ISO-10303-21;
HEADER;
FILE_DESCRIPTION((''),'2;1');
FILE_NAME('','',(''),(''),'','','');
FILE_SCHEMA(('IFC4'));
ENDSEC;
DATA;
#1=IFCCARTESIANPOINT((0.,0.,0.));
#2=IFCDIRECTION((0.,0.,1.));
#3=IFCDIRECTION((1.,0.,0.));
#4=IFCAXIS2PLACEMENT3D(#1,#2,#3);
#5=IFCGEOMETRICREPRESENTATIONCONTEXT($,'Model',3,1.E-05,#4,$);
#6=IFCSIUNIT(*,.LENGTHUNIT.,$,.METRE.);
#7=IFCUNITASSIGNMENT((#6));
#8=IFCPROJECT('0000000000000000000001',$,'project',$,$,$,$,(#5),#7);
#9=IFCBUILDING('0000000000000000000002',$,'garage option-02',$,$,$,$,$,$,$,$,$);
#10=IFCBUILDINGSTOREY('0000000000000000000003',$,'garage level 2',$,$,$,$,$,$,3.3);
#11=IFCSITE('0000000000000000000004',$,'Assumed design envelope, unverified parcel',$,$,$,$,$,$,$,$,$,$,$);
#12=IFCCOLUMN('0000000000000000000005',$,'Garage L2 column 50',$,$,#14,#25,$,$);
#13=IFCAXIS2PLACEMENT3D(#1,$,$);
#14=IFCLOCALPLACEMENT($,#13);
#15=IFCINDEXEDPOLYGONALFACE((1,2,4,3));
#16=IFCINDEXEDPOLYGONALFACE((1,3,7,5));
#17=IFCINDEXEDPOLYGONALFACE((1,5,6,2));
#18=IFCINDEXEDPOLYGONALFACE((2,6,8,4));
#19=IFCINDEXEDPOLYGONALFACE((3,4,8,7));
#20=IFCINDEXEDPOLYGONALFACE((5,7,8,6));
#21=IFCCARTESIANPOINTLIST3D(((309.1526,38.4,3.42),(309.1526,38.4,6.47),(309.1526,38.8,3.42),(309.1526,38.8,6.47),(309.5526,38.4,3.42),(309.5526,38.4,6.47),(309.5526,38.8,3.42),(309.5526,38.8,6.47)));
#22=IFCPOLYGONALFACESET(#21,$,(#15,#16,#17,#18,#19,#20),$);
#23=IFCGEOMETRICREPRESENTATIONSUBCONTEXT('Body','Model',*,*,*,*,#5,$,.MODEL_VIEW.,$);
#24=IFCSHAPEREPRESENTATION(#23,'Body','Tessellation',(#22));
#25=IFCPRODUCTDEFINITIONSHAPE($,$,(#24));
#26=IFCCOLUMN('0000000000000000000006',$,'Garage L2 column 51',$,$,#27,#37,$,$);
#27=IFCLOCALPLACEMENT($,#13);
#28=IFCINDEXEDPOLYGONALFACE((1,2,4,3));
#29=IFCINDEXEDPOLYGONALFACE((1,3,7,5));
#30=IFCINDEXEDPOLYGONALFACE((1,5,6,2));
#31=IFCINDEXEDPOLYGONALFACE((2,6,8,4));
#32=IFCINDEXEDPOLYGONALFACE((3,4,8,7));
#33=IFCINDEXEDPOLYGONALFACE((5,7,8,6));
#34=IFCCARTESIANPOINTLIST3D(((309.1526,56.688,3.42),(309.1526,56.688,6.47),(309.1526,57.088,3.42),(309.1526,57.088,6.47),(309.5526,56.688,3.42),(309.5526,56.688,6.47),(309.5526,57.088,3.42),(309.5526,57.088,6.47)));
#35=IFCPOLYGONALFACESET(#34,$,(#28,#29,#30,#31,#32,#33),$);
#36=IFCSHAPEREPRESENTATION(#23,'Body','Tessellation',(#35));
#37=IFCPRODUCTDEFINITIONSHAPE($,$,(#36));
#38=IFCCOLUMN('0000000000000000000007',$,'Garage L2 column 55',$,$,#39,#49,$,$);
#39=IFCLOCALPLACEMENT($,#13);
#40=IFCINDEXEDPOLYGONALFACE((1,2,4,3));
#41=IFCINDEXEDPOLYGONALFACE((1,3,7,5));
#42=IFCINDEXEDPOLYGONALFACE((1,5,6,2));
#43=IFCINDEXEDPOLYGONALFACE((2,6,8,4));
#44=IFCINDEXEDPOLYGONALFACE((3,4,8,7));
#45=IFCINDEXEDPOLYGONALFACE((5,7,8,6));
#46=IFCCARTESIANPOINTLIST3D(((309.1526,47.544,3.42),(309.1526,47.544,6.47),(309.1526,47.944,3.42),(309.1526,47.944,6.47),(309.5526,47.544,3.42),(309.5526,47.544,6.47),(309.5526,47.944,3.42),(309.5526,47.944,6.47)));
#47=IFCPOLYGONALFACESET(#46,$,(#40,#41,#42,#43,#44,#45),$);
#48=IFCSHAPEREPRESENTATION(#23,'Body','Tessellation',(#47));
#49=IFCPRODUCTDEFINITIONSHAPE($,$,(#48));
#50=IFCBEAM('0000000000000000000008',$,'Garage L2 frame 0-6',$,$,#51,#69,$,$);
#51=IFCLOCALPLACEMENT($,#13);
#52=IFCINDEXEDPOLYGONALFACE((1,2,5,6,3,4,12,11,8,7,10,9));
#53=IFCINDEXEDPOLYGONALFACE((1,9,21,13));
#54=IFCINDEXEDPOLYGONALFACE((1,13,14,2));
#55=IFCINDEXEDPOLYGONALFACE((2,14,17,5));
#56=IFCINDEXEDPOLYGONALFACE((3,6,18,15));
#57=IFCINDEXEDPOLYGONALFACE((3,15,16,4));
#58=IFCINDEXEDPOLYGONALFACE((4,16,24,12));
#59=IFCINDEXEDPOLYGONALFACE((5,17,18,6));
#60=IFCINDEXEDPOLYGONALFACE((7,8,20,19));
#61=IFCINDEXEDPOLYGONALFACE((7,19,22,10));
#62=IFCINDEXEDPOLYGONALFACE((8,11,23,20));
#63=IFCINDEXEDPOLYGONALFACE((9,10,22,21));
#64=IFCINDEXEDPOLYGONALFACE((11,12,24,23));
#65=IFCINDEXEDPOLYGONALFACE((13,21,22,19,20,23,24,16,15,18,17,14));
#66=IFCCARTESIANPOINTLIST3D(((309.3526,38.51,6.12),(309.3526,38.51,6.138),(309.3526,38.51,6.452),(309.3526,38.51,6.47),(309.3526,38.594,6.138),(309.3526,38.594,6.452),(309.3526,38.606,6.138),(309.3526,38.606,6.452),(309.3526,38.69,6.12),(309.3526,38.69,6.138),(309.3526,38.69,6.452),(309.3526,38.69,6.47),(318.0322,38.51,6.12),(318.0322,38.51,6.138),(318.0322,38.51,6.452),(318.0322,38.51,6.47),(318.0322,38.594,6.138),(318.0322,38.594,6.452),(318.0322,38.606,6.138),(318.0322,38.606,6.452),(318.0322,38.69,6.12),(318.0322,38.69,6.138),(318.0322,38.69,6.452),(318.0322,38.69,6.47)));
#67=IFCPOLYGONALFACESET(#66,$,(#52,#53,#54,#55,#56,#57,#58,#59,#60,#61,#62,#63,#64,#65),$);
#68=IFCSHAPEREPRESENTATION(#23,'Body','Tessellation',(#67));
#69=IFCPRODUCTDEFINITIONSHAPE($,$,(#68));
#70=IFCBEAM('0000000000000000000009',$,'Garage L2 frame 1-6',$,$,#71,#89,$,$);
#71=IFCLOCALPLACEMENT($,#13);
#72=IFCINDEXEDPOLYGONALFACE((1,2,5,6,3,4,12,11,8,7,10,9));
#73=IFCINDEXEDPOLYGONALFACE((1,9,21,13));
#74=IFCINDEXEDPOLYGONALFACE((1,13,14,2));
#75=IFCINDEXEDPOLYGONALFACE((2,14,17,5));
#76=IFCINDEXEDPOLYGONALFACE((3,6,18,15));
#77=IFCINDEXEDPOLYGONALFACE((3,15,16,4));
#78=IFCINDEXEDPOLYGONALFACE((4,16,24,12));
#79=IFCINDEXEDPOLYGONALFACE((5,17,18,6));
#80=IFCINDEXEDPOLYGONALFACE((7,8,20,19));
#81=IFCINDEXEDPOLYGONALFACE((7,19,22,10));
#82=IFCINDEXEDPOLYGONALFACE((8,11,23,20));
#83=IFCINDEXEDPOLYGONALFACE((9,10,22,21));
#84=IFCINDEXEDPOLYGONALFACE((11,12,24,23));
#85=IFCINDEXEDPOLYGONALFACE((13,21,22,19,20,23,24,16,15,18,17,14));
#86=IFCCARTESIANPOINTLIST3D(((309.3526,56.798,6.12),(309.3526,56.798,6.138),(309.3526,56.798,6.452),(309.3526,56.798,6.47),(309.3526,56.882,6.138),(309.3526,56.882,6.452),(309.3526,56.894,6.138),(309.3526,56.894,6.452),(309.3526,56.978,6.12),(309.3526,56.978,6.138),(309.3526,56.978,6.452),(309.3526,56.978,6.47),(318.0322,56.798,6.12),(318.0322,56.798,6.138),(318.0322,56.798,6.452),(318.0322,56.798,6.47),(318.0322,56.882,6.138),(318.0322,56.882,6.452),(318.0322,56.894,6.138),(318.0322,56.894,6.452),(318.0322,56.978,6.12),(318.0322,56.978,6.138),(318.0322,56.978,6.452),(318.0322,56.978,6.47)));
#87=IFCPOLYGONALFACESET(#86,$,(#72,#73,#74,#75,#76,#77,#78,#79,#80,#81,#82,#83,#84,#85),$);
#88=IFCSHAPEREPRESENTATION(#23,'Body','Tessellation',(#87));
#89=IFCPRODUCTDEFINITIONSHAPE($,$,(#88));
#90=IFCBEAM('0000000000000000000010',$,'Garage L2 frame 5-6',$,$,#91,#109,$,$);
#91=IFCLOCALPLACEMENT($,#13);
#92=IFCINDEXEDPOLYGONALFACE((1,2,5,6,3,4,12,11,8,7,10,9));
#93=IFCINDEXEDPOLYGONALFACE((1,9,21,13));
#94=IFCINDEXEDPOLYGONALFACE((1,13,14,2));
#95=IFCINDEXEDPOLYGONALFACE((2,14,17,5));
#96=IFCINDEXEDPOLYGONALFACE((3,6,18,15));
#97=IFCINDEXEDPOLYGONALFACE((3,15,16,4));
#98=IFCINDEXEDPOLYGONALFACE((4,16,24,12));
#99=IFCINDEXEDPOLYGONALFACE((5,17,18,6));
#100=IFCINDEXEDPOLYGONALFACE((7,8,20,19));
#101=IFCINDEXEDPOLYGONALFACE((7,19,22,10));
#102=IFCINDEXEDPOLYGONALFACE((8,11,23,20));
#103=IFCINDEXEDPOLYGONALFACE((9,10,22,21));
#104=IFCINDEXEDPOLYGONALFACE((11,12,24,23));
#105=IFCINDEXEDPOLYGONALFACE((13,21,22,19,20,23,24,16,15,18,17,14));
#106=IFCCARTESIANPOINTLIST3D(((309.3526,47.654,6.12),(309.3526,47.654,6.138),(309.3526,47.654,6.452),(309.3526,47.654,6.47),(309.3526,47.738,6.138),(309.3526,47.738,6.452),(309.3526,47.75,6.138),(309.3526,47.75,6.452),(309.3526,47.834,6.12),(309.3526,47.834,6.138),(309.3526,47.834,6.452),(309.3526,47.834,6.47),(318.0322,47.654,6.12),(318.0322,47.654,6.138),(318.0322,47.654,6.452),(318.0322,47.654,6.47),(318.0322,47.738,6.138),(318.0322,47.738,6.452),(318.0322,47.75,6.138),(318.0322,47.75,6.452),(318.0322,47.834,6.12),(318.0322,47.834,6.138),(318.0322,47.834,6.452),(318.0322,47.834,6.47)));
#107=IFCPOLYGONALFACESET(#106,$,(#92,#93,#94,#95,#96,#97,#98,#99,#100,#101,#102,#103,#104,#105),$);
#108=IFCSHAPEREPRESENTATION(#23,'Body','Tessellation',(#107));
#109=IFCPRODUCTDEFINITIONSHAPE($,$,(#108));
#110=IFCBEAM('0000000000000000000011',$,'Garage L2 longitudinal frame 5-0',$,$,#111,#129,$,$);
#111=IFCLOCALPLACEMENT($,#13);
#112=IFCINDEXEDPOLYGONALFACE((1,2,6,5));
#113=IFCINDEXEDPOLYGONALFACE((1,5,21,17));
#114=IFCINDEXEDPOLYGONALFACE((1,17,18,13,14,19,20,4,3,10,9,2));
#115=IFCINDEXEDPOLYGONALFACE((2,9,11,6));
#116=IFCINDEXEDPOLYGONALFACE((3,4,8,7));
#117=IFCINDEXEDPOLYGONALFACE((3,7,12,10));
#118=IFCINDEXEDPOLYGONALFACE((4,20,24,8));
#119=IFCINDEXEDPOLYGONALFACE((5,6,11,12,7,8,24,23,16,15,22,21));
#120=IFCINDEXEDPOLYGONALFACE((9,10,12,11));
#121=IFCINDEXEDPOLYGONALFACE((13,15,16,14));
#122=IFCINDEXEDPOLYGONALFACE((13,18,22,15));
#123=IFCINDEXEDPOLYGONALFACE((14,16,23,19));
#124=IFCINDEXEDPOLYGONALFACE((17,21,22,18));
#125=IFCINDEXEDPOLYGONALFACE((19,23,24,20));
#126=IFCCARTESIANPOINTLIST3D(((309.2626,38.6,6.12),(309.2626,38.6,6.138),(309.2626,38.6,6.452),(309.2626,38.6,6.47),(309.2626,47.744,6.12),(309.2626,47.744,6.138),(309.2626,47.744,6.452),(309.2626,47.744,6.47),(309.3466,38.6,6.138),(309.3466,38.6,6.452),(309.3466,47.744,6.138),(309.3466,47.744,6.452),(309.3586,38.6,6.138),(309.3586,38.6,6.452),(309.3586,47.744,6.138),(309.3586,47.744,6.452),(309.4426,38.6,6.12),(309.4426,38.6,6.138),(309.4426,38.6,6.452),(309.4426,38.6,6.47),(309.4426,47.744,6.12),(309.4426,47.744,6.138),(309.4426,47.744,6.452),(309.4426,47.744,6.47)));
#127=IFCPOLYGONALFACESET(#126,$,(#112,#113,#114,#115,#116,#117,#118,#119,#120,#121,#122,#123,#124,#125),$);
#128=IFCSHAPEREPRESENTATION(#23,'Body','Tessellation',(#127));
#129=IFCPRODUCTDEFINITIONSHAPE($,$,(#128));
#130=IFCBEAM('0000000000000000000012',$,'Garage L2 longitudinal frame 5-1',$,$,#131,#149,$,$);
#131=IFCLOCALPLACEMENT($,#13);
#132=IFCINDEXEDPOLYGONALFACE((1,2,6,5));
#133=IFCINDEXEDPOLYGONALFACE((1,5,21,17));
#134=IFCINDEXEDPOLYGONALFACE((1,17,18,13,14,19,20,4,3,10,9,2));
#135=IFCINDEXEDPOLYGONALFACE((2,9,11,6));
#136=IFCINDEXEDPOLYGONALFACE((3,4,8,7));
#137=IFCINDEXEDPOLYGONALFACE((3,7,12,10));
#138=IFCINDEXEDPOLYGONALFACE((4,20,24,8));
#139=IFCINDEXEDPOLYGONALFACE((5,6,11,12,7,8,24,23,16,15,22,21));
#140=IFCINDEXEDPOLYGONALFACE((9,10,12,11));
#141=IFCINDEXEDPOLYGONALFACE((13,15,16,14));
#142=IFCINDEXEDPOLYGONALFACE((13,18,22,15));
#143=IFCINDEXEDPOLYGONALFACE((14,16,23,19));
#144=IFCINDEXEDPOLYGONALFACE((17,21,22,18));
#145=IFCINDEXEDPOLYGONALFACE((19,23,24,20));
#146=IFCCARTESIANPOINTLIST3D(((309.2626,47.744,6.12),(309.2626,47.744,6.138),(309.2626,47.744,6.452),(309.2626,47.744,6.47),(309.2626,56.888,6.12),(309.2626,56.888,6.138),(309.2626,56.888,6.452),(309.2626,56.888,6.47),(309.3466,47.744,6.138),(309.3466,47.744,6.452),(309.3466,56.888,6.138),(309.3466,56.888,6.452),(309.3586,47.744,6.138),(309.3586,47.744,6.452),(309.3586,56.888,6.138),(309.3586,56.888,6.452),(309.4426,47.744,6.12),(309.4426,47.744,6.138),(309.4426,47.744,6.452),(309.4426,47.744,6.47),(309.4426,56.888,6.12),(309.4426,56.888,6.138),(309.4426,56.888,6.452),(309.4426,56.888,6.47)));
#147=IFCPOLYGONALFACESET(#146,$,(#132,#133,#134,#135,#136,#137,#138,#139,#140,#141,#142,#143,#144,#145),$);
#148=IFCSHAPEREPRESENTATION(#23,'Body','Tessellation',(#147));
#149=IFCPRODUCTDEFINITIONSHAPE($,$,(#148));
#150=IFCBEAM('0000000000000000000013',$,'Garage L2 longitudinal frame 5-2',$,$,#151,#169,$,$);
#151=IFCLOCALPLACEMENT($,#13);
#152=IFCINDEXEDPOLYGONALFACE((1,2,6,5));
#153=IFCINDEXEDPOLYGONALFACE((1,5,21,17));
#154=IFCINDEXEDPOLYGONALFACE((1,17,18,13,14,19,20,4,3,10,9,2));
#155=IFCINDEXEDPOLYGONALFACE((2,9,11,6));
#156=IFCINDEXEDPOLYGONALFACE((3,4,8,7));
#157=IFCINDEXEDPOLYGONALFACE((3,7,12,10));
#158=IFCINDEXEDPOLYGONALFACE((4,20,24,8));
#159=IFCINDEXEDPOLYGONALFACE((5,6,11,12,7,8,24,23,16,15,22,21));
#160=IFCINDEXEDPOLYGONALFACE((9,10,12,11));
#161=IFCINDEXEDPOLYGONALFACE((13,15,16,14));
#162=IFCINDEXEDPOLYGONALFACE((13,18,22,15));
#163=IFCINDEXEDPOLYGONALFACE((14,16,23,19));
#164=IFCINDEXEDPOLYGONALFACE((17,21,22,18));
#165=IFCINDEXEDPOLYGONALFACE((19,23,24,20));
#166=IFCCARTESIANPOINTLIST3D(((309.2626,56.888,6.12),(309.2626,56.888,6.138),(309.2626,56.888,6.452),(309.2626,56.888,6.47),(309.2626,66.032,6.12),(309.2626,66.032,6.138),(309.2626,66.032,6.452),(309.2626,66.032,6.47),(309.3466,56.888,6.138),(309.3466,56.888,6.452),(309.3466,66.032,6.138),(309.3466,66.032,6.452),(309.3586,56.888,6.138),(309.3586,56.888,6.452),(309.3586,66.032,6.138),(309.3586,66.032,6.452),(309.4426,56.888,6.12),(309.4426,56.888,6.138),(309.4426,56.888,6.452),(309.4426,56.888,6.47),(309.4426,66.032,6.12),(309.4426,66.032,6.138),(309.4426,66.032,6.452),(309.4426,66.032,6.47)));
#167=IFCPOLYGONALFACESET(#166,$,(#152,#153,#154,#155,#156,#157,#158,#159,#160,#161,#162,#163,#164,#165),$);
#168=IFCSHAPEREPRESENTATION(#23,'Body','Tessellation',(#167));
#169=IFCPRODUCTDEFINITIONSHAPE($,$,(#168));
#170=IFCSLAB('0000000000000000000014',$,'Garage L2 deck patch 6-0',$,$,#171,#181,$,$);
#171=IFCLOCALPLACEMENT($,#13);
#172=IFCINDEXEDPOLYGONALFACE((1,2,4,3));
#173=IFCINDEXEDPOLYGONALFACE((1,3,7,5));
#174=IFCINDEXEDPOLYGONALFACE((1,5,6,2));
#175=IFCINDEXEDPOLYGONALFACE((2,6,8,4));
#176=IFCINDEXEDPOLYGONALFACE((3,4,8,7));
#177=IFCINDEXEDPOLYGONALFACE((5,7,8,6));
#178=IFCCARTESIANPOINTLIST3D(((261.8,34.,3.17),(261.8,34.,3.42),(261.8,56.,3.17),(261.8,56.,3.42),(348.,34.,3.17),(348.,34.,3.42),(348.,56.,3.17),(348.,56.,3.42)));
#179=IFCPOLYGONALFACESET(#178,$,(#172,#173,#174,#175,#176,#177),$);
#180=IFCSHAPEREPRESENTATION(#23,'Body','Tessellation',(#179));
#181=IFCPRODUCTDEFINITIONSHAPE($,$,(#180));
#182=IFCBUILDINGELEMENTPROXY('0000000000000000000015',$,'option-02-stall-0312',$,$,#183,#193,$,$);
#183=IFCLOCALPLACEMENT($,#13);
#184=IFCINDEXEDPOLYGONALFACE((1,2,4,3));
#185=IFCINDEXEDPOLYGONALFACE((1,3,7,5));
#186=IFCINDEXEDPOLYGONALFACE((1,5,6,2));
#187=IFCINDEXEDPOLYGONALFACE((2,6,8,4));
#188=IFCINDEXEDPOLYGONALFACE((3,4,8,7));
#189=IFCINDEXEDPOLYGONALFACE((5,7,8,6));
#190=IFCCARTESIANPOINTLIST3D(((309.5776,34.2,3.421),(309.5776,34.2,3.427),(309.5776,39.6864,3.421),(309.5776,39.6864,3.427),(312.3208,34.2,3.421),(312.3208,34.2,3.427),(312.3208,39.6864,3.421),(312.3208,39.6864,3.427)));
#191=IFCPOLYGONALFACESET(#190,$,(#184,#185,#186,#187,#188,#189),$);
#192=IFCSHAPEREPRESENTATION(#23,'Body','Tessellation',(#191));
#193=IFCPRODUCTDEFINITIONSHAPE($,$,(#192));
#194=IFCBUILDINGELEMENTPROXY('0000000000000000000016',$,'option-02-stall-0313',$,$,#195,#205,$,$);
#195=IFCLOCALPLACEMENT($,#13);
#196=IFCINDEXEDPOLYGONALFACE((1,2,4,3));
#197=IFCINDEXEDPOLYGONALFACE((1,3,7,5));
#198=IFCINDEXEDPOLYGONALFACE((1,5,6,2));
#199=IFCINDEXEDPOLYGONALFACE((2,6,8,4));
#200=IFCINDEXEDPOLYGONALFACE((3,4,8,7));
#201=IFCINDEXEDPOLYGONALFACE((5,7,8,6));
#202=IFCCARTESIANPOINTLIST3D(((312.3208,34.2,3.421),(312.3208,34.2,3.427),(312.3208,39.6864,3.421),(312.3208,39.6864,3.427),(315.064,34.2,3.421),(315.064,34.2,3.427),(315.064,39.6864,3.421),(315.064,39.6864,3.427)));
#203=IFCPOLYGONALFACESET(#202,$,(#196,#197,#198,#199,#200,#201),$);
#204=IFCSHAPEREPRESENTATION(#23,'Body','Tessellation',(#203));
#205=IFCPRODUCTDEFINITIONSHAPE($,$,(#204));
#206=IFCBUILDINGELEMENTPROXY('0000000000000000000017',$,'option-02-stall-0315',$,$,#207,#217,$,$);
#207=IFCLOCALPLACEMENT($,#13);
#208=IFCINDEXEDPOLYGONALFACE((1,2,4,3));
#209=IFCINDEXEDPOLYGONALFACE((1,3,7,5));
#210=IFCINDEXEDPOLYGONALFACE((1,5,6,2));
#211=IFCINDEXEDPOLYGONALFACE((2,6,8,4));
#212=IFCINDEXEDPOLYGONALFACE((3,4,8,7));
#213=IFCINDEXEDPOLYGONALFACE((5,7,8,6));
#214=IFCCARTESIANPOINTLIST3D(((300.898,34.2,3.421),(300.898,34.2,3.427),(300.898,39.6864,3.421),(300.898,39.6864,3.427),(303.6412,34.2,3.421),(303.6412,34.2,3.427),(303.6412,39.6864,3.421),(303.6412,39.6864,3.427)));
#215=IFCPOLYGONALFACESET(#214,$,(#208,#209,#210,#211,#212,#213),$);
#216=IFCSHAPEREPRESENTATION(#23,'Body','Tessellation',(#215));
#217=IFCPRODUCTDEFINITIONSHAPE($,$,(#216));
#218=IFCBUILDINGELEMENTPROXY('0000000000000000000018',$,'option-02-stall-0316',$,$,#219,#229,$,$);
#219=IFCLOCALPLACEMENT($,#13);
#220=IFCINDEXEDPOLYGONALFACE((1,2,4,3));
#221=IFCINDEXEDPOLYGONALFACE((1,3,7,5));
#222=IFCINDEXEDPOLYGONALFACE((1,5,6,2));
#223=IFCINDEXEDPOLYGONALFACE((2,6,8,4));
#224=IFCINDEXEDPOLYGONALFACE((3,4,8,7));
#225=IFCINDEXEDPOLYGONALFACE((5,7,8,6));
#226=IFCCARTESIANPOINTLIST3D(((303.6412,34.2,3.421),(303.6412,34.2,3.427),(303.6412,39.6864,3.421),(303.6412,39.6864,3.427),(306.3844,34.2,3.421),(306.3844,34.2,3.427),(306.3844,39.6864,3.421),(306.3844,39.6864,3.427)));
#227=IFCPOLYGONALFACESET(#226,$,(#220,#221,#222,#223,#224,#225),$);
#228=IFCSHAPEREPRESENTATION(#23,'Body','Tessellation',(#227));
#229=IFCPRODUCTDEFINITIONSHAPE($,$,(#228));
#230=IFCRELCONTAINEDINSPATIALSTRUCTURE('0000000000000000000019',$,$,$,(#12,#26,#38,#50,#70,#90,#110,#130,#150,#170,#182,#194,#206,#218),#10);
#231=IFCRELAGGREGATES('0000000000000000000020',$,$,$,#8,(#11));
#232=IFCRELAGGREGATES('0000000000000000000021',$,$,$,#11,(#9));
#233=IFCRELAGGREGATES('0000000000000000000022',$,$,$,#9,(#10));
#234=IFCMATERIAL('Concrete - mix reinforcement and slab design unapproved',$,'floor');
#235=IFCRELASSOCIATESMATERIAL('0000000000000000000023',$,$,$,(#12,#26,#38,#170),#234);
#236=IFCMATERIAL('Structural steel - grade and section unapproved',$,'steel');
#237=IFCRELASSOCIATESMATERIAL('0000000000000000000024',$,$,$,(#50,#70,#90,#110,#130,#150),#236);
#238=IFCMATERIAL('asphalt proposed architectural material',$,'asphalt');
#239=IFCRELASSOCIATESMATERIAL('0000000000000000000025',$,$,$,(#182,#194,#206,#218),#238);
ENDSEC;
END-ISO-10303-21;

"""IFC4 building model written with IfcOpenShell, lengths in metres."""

from ifc_helpers import new_model, si_unit, frame, origin_with_axes, place, context, subcontext, project, spatial, rectangle, i_section, extrude, material, element, save


model = new_model("IFC4")

# Units and contexts
model_context = context("Model", 3, precision=1e-05, world=origin_with_axes())
body_context = subcontext(model_context, "Body", "Model", "MODEL_VIEW")
ifc_project = project(units=[si_unit("LENGTHUNIT", "METRE")], contexts=[model_context])

# Site, building, storey
site = spatial("IfcSite", under=ifc_project, Name="Assumed design envelope, unverified parcel")
building = spatial("IfcBuilding", under=site, Name="garage option-02")
storey = spatial("IfcBuildingStorey", under=building, Name="garage level 2", Elevation=3.3)

# Columns
ifc_material_1 = material(Name="Concrete - mix reinforcement and slab design unapproved", Category="floor")
for number, where, z_axis, x_axis, name in (
    (1, (309.3526, 38.6, 3.42), (0.0, 0.0, 1.0), (1.0, 0.0, 0.0), "Garage L2 column 50"),
    (2, (309.3526, 56.888, 3.42), (0.0, 0.0, 1.0), (1.0, 0.0, 0.0), "Garage L2 column 51"),
    (3, (309.3526, 47.744, 3.42), (0.0, 0.0, 1.0), (1.0, 0.0, 0.0), "Garage L2 column 55"),
):
    element("IfcColumn", number, at=place(None, frame(where, z_axis=z_axis, x_axis=x_axis)), inside=storey, material=ifc_material_1, Name=name, context=body_context, shape_type="SweptSolid", body=[
        extrude(rectangle(XDim=0.4, YDim=0.4), origin_with_axes(), (0.0, 0.0, 1.0), 3.05),
    ])

# Beams
ifc_material_2 = material(Name="Structural steel - grade and section unapproved", Category="steel")
for number, where, z_axis, x_axis, name in (
    (4, (309.3526, 38.6, 6.295), (1.0, 0.0, 0.0), (0.0, 1.0, 0.0), "Garage L2 frame 0-6"),
    (5, (309.3526, 56.888, 6.295), (1.0, 0.0, 0.0), (0.0, 1.0, 0.0), "Garage L2 frame 1-6"),
    (6, (309.3526, 47.744, 6.295), (1.0, 0.0, 0.0), (0.0, 1.0, 0.0), "Garage L2 frame 5-6"),
):
    element("IfcBeam", number, at=place(None, frame(where, z_axis=z_axis, x_axis=x_axis)), inside=storey, material=ifc_material_2, Name=name, context=body_context, shape_type="SweptSolid", body=[
        extrude(i_section(OverallWidth=0.18, OverallDepth=0.35, WebThickness=0.012, FlangeThickness=0.018, FilletRadius=0.0), origin_with_axes(), (0.0, 0.0, 1.0), 8.6796),
    ])
for number, where, z_axis, x_axis, name in (
    (7, (309.3526, 38.6, 6.295), (0.0, 1.0, 0.0), (-1.0, 0.0, 0.0), "Garage L2 longitudinal frame 5-0"),
    (8, (309.3526, 47.744, 6.295), (0.0, 1.0, 0.0), (-1.0, 0.0, 0.0), "Garage L2 longitudinal frame 5-1"),
):
    element("IfcBeam", number, at=place(None, frame(where, z_axis=z_axis, x_axis=x_axis)), inside=storey, material=ifc_material_2, Name=name, context=body_context, shape_type="SweptSolid", body=[
        extrude(i_section(OverallWidth=0.18, OverallDepth=0.35, WebThickness=0.012, FlangeThickness=0.018, FilletRadius=0.0), origin_with_axes(), (0.0, 0.0, 1.0), 9.144),
    ])
beam_placement = place(None, frame((309.3526, 56.888, 6.295), z_axis=(0.0, 1.0, 0.0), x_axis=(-1.0, 0.0, 0.0)))
element("IfcBeam", 9, at=beam_placement, inside=storey, material=ifc_material_2, Name="Garage L2 longitudinal frame 5-2", context=body_context, shape_type="SweptSolid", body=[
    extrude(i_section(OverallWidth=0.18, OverallDepth=0.35, WebThickness=0.012, FlangeThickness=0.018, FilletRadius=0.0), origin_with_axes(), (0.0, 0.0, 1.0), 9.144),
])

# Slab
slab_placement = place(None, frame((304.9, 45.0, 3.17), z_axis=(0.0, 0.0, 1.0), x_axis=(1.0, 0.0, 0.0)))
element("IfcSlab", 10, at=slab_placement, inside=storey, material=ifc_material_1, Name="Garage L2 deck patch 6-0", context=body_context, shape_type="SweptSolid", body=[
    extrude(rectangle(XDim=86.2, YDim=22.0), origin_with_axes(), (0.0, 0.0, 1.0), 0.25),
])

# Building element proxies
ifc_material_3 = material(Name="asphalt proposed architectural material", Category="asphalt")
for number, where, z_axis, x_axis, name in (
    (11, (310.9492, 36.9432, 3.421), (0.0, 0.0, 1.0), (1.0, 0.0, 0.0), "option-02-stall-0312"),
    (12, (313.6924, 36.9432, 3.421), (0.0, 0.0, 1.0), (1.0, 0.0, 0.0), "option-02-stall-0313"),
    (13, (302.2696, 36.9432, 3.421), (0.0, 0.0, 1.0), (1.0, 0.0, 0.0), "option-02-stall-0315"),
    (14, (305.0128, 36.9432, 3.421), (0.0, 0.0, 1.0), (1.0, 0.0, 0.0), "option-02-stall-0316"),
):
    element("IfcBuildingElementProxy", number, at=place(None, frame(where, z_axis=z_axis, x_axis=x_axis)), inside=storey, material=ifc_material_3, Name=name, context=body_context, shape_type="SweptSolid", body=[
        extrude(rectangle(XDim=2.7432, YDim=5.4864), origin_with_axes(), (0.0, 0.0, 1.0), 0.006),
    ])

save(model, "model.ifc")
